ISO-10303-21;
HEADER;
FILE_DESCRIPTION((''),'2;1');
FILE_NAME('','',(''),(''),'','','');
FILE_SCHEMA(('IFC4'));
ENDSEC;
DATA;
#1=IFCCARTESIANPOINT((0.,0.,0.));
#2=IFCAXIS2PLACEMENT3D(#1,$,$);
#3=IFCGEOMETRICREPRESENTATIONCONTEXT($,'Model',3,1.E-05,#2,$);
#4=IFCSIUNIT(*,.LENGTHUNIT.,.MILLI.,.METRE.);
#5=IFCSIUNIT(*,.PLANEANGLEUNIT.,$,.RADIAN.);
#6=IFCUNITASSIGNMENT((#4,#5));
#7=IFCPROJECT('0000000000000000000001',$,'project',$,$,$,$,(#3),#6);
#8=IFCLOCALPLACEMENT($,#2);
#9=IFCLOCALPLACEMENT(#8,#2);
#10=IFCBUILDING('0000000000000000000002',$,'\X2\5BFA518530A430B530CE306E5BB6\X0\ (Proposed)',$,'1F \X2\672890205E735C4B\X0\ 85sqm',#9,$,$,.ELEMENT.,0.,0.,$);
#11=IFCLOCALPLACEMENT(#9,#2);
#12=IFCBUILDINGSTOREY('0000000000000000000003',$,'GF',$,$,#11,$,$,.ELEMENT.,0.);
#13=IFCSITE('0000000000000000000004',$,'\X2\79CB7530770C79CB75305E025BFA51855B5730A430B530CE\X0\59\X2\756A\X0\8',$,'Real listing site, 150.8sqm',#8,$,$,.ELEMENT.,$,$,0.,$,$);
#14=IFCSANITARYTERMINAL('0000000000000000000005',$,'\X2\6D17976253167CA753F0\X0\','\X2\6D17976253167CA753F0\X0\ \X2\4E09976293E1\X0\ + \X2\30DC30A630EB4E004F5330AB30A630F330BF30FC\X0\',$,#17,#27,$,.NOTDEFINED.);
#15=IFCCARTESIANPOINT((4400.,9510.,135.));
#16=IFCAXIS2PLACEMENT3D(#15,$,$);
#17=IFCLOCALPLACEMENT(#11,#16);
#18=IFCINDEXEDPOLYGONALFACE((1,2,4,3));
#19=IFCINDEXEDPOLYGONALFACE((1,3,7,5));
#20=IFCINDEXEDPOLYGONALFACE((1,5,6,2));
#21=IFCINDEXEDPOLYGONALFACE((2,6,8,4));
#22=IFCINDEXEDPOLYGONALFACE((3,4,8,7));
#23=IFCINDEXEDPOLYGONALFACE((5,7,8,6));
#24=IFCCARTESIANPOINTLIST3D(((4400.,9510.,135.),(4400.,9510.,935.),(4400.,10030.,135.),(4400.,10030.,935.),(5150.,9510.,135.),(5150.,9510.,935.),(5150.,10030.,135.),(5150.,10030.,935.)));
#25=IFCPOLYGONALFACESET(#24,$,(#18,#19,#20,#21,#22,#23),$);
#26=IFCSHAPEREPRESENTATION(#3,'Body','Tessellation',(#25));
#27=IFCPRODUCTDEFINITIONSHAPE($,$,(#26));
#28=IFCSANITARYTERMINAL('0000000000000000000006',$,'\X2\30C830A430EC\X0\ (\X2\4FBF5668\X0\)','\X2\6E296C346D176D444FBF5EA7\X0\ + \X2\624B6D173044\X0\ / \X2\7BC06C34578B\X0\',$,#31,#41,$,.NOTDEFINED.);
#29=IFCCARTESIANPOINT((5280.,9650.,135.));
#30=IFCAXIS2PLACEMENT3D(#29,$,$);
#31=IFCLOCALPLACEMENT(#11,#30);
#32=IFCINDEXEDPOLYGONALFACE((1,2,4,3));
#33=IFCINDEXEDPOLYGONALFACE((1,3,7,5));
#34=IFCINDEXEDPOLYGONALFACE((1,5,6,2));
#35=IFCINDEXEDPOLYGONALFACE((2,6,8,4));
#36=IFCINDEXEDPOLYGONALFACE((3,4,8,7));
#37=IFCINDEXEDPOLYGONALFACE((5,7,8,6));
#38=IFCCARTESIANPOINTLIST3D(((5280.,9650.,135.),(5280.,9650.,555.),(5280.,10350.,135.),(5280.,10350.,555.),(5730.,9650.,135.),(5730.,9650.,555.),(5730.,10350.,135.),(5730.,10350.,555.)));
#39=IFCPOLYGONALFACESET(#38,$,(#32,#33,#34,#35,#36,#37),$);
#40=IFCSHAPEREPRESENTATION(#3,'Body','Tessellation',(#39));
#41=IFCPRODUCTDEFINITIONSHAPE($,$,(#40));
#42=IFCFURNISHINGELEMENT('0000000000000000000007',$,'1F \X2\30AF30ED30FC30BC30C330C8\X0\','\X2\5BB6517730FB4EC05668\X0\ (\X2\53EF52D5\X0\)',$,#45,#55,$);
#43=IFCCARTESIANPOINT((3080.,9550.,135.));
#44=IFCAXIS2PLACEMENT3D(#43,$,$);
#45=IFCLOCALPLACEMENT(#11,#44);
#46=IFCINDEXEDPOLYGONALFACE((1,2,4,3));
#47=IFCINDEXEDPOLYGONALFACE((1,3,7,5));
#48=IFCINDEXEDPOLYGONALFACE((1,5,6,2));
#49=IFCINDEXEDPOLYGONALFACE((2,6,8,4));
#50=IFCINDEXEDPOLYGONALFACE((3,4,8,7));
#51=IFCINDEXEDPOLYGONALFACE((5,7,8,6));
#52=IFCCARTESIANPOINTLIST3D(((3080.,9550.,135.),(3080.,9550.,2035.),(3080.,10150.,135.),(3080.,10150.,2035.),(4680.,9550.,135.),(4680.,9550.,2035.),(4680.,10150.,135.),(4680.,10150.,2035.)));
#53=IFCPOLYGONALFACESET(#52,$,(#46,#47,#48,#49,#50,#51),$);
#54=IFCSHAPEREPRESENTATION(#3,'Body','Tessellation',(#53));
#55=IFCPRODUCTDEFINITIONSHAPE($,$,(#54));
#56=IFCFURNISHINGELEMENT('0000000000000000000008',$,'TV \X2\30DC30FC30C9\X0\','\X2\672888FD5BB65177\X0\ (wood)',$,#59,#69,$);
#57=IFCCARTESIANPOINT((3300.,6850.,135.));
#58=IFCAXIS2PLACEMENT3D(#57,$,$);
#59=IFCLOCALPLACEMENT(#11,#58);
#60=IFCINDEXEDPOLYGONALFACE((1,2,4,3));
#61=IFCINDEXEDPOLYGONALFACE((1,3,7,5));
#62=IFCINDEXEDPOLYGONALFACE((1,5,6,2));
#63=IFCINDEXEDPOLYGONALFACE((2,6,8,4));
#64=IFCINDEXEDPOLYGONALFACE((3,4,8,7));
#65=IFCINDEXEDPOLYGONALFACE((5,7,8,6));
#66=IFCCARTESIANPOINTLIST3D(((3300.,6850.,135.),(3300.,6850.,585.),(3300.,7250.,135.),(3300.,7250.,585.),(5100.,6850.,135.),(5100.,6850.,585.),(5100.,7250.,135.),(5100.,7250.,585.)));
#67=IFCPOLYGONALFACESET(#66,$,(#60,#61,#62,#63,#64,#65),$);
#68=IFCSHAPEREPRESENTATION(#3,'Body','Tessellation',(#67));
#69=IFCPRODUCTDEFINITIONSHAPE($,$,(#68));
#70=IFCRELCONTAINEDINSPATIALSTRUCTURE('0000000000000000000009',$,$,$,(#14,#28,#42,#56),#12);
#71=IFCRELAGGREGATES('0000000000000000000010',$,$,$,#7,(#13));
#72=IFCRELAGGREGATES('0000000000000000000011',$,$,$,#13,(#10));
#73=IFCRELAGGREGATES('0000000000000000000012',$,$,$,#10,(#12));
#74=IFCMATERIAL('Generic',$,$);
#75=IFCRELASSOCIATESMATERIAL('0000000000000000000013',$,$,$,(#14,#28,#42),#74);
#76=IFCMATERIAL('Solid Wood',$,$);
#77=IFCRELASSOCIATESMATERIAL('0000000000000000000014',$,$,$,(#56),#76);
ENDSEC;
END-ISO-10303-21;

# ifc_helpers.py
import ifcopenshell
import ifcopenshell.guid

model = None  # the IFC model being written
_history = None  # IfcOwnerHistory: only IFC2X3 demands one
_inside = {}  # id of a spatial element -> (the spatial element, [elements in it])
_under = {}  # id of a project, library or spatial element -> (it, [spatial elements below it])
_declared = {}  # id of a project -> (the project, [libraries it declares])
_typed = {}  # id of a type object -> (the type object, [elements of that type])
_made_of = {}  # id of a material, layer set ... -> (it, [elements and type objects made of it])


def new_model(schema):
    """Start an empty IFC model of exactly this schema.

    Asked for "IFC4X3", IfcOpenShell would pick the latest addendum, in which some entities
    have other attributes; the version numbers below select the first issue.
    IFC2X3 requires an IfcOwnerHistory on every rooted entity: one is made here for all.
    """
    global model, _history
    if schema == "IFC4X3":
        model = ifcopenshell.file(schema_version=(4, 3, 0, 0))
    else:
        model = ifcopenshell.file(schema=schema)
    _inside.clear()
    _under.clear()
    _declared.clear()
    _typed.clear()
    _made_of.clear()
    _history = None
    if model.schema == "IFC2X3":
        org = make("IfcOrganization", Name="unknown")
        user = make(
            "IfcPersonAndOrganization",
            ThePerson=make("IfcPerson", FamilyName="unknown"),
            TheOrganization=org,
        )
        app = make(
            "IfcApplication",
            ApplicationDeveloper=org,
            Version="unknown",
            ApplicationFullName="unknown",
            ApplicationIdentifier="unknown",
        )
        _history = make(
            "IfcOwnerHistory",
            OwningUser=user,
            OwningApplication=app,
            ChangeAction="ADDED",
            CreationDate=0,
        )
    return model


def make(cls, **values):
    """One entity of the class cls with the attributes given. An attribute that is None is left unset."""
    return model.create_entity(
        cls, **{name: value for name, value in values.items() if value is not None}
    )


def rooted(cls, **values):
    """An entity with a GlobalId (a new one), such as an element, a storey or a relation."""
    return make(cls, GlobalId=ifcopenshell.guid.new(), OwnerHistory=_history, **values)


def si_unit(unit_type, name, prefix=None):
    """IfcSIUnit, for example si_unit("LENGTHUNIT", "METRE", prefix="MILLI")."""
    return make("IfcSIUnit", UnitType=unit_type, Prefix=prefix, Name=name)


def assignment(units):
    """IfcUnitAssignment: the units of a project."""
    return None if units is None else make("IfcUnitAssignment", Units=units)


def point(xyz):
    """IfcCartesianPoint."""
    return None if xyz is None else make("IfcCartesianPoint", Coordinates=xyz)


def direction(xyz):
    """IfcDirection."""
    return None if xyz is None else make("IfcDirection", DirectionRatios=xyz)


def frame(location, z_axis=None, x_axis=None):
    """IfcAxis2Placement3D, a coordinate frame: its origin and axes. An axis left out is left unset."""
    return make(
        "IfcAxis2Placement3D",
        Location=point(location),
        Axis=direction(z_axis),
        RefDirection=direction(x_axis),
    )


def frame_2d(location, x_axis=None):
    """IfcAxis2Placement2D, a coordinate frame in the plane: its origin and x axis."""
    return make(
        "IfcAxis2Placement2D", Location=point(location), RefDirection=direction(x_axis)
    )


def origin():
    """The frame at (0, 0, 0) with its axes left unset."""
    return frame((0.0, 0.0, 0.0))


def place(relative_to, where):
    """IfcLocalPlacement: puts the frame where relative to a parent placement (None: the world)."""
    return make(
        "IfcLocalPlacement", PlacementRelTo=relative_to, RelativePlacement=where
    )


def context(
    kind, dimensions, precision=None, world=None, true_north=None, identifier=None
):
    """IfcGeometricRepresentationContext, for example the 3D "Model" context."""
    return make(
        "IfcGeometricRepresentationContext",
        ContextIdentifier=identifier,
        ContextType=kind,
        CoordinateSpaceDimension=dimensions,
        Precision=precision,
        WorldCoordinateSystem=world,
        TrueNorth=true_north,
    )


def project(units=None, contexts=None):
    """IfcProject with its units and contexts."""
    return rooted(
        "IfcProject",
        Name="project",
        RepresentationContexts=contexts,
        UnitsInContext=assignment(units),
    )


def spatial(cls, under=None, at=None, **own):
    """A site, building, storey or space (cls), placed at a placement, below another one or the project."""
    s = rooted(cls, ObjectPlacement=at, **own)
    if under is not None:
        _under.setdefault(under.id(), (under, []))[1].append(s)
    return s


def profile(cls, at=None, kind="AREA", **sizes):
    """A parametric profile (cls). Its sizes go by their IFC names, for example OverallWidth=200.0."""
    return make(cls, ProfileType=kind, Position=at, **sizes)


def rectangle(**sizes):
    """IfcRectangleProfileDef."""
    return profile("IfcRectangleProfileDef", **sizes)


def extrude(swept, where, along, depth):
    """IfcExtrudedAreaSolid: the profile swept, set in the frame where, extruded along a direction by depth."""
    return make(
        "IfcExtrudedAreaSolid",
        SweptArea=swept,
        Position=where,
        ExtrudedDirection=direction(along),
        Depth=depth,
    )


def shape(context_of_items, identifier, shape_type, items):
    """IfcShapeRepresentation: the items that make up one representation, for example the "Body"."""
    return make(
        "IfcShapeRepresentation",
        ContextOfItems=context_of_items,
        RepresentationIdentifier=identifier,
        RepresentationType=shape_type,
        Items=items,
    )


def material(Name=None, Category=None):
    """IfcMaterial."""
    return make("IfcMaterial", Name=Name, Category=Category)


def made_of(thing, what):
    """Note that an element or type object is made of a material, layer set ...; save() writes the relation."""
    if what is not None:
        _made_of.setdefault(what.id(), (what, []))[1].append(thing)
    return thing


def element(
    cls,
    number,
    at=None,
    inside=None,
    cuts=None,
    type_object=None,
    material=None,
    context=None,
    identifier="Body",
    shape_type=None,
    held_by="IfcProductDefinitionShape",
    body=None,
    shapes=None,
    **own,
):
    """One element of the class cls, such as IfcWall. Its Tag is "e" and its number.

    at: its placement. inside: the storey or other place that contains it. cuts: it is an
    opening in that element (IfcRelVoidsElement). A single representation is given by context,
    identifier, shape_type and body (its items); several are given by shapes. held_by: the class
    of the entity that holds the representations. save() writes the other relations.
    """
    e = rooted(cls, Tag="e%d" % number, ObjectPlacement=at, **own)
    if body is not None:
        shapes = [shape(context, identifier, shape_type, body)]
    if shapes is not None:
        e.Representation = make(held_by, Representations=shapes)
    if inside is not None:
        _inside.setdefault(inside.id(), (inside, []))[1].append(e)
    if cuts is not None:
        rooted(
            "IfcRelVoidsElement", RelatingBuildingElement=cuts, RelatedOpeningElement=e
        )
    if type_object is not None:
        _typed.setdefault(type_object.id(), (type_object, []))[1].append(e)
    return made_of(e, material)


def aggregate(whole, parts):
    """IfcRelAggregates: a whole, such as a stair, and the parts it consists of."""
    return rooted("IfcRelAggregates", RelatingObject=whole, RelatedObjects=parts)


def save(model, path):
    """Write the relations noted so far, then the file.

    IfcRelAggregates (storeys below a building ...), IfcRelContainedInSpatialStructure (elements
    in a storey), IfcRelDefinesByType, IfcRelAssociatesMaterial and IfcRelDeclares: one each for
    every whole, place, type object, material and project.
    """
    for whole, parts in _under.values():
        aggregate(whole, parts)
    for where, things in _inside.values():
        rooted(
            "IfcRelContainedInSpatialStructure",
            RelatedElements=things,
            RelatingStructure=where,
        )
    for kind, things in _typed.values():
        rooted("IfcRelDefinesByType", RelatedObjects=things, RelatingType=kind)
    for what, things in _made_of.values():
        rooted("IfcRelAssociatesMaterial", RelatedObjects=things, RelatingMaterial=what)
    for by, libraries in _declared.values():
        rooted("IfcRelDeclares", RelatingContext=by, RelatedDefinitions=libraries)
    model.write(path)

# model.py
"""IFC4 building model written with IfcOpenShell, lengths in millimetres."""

from ifc_helpers import new_model, si_unit, frame, frame_2d, origin, place, context, project, spatial, rectangle, extrude, material, element, save


model = new_model("IFC4")

# Units and contexts
model_context = context("Model", 3, precision=1e-05, world=origin())
ifc_project = project(units=[si_unit("LENGTHUNIT", "METRE", prefix="MILLI"), si_unit("PLANEANGLEUNIT", "RADIAN")], contexts=[model_context])

# Site, building, storey
site_placement = place(None, origin())
site = spatial("IfcSite", under=ifc_project, at=site_placement, Name="秋田県秋田市寺内字イサノ59番8", ObjectType="Real listing site, 150.8sqm", CompositionType="ELEMENT", RefElevation=0.0)
building_placement = place(site_placement, origin())
building = spatial("IfcBuilding", under=site, at=building_placement, Name="寺内イサノの家 (Proposed)", ObjectType="1F 木造平屋 85sqm", CompositionType="ELEMENT", ElevationOfRefHeight=0.0, ElevationOfTerrain=0.0)
storey_placement = place(building_placement, origin())
storey = spatial("IfcBuildingStorey", under=building, at=storey_placement, Name="GF", CompositionType="ELEMENT", Elevation=0.0)

# Shared definitions
ifc_material_1 = material(Name="Solid Wood")

# Shared definitions
ifc_material_2 = material(Name="Generic")

# Sanitary terminals
sanitary_terminal_1_placement = place(storey_placement, frame((4400.0, 9510.0, 135.0)))
element("IfcSanitaryTerminal", 1, at=sanitary_terminal_1_placement, inside=storey, material=ifc_material_2, Name="洗面化粧台", Description="洗面化粧台 三面鏡 + ボウル一体カウンター", PredefinedType="NOTDEFINED", context=model_context, shape_type="SweptSolid", body=[
    extrude(rectangle(XDim=750.0, YDim=520.0, at=frame_2d((375.0, 260.0))), frame((4400.0, 9510.0, 135.0)), (0.0, 0.0, 1.0), 800.0),
])
sanitary_terminal_2_placement = place(storey_placement, frame((5280.0, 9650.0, 135.0)))
element("IfcSanitaryTerminal", 2, at=sanitary_terminal_2_placement, inside=storey, material=ifc_material_2, Name="トイレ (便器)", Description="温水洗浄便座 + 手洗い / 節水型", PredefinedType="NOTDEFINED", context=model_context, shape_type="SweptSolid", body=[
    extrude(rectangle(XDim=450.0, YDim=700.0, at=frame_2d((225.0, 350.0))), frame((5280.0, 9650.0, 135.0)), (0.0, 0.0, 1.0), 420.0),
])

# Furnishing elements
furnishing_1_placement = place(storey_placement, frame((3080.0, 9550.0, 135.0)))
element("IfcFurnishingElement", 3, at=furnishing_1_placement, inside=storey, material=ifc_material_2, Name="1F クローゼット", Description="家具・什器 (可動)", context=model_context, shape_type="SweptSolid", body=[
    extrude(rectangle(XDim=1600.0, YDim=600.0, at=frame_2d((800.0, 300.0))), frame((3080.0, 9550.0, 135.0)), (0.0, 0.0, 1.0), 1900.0),
])
furnishing_2_placement = place(storey_placement, frame((3300.0, 6850.0, 135.0)))
element("IfcFurnishingElement", 4, at=furnishing_2_placement, inside=storey, material=ifc_material_1, Name="TV ボード", Description="木製家具 (wood)", context=model_context, shape_type="SweptSolid", body=[
    extrude(rectangle(XDim=1800.0, YDim=400.0, at=frame_2d((900.0, 200.0))), frame((3300.0, 6850.0, 135.0)), (0.0, 0.0, 1.0), 450.0),
])

save(model, "model.ifc")
